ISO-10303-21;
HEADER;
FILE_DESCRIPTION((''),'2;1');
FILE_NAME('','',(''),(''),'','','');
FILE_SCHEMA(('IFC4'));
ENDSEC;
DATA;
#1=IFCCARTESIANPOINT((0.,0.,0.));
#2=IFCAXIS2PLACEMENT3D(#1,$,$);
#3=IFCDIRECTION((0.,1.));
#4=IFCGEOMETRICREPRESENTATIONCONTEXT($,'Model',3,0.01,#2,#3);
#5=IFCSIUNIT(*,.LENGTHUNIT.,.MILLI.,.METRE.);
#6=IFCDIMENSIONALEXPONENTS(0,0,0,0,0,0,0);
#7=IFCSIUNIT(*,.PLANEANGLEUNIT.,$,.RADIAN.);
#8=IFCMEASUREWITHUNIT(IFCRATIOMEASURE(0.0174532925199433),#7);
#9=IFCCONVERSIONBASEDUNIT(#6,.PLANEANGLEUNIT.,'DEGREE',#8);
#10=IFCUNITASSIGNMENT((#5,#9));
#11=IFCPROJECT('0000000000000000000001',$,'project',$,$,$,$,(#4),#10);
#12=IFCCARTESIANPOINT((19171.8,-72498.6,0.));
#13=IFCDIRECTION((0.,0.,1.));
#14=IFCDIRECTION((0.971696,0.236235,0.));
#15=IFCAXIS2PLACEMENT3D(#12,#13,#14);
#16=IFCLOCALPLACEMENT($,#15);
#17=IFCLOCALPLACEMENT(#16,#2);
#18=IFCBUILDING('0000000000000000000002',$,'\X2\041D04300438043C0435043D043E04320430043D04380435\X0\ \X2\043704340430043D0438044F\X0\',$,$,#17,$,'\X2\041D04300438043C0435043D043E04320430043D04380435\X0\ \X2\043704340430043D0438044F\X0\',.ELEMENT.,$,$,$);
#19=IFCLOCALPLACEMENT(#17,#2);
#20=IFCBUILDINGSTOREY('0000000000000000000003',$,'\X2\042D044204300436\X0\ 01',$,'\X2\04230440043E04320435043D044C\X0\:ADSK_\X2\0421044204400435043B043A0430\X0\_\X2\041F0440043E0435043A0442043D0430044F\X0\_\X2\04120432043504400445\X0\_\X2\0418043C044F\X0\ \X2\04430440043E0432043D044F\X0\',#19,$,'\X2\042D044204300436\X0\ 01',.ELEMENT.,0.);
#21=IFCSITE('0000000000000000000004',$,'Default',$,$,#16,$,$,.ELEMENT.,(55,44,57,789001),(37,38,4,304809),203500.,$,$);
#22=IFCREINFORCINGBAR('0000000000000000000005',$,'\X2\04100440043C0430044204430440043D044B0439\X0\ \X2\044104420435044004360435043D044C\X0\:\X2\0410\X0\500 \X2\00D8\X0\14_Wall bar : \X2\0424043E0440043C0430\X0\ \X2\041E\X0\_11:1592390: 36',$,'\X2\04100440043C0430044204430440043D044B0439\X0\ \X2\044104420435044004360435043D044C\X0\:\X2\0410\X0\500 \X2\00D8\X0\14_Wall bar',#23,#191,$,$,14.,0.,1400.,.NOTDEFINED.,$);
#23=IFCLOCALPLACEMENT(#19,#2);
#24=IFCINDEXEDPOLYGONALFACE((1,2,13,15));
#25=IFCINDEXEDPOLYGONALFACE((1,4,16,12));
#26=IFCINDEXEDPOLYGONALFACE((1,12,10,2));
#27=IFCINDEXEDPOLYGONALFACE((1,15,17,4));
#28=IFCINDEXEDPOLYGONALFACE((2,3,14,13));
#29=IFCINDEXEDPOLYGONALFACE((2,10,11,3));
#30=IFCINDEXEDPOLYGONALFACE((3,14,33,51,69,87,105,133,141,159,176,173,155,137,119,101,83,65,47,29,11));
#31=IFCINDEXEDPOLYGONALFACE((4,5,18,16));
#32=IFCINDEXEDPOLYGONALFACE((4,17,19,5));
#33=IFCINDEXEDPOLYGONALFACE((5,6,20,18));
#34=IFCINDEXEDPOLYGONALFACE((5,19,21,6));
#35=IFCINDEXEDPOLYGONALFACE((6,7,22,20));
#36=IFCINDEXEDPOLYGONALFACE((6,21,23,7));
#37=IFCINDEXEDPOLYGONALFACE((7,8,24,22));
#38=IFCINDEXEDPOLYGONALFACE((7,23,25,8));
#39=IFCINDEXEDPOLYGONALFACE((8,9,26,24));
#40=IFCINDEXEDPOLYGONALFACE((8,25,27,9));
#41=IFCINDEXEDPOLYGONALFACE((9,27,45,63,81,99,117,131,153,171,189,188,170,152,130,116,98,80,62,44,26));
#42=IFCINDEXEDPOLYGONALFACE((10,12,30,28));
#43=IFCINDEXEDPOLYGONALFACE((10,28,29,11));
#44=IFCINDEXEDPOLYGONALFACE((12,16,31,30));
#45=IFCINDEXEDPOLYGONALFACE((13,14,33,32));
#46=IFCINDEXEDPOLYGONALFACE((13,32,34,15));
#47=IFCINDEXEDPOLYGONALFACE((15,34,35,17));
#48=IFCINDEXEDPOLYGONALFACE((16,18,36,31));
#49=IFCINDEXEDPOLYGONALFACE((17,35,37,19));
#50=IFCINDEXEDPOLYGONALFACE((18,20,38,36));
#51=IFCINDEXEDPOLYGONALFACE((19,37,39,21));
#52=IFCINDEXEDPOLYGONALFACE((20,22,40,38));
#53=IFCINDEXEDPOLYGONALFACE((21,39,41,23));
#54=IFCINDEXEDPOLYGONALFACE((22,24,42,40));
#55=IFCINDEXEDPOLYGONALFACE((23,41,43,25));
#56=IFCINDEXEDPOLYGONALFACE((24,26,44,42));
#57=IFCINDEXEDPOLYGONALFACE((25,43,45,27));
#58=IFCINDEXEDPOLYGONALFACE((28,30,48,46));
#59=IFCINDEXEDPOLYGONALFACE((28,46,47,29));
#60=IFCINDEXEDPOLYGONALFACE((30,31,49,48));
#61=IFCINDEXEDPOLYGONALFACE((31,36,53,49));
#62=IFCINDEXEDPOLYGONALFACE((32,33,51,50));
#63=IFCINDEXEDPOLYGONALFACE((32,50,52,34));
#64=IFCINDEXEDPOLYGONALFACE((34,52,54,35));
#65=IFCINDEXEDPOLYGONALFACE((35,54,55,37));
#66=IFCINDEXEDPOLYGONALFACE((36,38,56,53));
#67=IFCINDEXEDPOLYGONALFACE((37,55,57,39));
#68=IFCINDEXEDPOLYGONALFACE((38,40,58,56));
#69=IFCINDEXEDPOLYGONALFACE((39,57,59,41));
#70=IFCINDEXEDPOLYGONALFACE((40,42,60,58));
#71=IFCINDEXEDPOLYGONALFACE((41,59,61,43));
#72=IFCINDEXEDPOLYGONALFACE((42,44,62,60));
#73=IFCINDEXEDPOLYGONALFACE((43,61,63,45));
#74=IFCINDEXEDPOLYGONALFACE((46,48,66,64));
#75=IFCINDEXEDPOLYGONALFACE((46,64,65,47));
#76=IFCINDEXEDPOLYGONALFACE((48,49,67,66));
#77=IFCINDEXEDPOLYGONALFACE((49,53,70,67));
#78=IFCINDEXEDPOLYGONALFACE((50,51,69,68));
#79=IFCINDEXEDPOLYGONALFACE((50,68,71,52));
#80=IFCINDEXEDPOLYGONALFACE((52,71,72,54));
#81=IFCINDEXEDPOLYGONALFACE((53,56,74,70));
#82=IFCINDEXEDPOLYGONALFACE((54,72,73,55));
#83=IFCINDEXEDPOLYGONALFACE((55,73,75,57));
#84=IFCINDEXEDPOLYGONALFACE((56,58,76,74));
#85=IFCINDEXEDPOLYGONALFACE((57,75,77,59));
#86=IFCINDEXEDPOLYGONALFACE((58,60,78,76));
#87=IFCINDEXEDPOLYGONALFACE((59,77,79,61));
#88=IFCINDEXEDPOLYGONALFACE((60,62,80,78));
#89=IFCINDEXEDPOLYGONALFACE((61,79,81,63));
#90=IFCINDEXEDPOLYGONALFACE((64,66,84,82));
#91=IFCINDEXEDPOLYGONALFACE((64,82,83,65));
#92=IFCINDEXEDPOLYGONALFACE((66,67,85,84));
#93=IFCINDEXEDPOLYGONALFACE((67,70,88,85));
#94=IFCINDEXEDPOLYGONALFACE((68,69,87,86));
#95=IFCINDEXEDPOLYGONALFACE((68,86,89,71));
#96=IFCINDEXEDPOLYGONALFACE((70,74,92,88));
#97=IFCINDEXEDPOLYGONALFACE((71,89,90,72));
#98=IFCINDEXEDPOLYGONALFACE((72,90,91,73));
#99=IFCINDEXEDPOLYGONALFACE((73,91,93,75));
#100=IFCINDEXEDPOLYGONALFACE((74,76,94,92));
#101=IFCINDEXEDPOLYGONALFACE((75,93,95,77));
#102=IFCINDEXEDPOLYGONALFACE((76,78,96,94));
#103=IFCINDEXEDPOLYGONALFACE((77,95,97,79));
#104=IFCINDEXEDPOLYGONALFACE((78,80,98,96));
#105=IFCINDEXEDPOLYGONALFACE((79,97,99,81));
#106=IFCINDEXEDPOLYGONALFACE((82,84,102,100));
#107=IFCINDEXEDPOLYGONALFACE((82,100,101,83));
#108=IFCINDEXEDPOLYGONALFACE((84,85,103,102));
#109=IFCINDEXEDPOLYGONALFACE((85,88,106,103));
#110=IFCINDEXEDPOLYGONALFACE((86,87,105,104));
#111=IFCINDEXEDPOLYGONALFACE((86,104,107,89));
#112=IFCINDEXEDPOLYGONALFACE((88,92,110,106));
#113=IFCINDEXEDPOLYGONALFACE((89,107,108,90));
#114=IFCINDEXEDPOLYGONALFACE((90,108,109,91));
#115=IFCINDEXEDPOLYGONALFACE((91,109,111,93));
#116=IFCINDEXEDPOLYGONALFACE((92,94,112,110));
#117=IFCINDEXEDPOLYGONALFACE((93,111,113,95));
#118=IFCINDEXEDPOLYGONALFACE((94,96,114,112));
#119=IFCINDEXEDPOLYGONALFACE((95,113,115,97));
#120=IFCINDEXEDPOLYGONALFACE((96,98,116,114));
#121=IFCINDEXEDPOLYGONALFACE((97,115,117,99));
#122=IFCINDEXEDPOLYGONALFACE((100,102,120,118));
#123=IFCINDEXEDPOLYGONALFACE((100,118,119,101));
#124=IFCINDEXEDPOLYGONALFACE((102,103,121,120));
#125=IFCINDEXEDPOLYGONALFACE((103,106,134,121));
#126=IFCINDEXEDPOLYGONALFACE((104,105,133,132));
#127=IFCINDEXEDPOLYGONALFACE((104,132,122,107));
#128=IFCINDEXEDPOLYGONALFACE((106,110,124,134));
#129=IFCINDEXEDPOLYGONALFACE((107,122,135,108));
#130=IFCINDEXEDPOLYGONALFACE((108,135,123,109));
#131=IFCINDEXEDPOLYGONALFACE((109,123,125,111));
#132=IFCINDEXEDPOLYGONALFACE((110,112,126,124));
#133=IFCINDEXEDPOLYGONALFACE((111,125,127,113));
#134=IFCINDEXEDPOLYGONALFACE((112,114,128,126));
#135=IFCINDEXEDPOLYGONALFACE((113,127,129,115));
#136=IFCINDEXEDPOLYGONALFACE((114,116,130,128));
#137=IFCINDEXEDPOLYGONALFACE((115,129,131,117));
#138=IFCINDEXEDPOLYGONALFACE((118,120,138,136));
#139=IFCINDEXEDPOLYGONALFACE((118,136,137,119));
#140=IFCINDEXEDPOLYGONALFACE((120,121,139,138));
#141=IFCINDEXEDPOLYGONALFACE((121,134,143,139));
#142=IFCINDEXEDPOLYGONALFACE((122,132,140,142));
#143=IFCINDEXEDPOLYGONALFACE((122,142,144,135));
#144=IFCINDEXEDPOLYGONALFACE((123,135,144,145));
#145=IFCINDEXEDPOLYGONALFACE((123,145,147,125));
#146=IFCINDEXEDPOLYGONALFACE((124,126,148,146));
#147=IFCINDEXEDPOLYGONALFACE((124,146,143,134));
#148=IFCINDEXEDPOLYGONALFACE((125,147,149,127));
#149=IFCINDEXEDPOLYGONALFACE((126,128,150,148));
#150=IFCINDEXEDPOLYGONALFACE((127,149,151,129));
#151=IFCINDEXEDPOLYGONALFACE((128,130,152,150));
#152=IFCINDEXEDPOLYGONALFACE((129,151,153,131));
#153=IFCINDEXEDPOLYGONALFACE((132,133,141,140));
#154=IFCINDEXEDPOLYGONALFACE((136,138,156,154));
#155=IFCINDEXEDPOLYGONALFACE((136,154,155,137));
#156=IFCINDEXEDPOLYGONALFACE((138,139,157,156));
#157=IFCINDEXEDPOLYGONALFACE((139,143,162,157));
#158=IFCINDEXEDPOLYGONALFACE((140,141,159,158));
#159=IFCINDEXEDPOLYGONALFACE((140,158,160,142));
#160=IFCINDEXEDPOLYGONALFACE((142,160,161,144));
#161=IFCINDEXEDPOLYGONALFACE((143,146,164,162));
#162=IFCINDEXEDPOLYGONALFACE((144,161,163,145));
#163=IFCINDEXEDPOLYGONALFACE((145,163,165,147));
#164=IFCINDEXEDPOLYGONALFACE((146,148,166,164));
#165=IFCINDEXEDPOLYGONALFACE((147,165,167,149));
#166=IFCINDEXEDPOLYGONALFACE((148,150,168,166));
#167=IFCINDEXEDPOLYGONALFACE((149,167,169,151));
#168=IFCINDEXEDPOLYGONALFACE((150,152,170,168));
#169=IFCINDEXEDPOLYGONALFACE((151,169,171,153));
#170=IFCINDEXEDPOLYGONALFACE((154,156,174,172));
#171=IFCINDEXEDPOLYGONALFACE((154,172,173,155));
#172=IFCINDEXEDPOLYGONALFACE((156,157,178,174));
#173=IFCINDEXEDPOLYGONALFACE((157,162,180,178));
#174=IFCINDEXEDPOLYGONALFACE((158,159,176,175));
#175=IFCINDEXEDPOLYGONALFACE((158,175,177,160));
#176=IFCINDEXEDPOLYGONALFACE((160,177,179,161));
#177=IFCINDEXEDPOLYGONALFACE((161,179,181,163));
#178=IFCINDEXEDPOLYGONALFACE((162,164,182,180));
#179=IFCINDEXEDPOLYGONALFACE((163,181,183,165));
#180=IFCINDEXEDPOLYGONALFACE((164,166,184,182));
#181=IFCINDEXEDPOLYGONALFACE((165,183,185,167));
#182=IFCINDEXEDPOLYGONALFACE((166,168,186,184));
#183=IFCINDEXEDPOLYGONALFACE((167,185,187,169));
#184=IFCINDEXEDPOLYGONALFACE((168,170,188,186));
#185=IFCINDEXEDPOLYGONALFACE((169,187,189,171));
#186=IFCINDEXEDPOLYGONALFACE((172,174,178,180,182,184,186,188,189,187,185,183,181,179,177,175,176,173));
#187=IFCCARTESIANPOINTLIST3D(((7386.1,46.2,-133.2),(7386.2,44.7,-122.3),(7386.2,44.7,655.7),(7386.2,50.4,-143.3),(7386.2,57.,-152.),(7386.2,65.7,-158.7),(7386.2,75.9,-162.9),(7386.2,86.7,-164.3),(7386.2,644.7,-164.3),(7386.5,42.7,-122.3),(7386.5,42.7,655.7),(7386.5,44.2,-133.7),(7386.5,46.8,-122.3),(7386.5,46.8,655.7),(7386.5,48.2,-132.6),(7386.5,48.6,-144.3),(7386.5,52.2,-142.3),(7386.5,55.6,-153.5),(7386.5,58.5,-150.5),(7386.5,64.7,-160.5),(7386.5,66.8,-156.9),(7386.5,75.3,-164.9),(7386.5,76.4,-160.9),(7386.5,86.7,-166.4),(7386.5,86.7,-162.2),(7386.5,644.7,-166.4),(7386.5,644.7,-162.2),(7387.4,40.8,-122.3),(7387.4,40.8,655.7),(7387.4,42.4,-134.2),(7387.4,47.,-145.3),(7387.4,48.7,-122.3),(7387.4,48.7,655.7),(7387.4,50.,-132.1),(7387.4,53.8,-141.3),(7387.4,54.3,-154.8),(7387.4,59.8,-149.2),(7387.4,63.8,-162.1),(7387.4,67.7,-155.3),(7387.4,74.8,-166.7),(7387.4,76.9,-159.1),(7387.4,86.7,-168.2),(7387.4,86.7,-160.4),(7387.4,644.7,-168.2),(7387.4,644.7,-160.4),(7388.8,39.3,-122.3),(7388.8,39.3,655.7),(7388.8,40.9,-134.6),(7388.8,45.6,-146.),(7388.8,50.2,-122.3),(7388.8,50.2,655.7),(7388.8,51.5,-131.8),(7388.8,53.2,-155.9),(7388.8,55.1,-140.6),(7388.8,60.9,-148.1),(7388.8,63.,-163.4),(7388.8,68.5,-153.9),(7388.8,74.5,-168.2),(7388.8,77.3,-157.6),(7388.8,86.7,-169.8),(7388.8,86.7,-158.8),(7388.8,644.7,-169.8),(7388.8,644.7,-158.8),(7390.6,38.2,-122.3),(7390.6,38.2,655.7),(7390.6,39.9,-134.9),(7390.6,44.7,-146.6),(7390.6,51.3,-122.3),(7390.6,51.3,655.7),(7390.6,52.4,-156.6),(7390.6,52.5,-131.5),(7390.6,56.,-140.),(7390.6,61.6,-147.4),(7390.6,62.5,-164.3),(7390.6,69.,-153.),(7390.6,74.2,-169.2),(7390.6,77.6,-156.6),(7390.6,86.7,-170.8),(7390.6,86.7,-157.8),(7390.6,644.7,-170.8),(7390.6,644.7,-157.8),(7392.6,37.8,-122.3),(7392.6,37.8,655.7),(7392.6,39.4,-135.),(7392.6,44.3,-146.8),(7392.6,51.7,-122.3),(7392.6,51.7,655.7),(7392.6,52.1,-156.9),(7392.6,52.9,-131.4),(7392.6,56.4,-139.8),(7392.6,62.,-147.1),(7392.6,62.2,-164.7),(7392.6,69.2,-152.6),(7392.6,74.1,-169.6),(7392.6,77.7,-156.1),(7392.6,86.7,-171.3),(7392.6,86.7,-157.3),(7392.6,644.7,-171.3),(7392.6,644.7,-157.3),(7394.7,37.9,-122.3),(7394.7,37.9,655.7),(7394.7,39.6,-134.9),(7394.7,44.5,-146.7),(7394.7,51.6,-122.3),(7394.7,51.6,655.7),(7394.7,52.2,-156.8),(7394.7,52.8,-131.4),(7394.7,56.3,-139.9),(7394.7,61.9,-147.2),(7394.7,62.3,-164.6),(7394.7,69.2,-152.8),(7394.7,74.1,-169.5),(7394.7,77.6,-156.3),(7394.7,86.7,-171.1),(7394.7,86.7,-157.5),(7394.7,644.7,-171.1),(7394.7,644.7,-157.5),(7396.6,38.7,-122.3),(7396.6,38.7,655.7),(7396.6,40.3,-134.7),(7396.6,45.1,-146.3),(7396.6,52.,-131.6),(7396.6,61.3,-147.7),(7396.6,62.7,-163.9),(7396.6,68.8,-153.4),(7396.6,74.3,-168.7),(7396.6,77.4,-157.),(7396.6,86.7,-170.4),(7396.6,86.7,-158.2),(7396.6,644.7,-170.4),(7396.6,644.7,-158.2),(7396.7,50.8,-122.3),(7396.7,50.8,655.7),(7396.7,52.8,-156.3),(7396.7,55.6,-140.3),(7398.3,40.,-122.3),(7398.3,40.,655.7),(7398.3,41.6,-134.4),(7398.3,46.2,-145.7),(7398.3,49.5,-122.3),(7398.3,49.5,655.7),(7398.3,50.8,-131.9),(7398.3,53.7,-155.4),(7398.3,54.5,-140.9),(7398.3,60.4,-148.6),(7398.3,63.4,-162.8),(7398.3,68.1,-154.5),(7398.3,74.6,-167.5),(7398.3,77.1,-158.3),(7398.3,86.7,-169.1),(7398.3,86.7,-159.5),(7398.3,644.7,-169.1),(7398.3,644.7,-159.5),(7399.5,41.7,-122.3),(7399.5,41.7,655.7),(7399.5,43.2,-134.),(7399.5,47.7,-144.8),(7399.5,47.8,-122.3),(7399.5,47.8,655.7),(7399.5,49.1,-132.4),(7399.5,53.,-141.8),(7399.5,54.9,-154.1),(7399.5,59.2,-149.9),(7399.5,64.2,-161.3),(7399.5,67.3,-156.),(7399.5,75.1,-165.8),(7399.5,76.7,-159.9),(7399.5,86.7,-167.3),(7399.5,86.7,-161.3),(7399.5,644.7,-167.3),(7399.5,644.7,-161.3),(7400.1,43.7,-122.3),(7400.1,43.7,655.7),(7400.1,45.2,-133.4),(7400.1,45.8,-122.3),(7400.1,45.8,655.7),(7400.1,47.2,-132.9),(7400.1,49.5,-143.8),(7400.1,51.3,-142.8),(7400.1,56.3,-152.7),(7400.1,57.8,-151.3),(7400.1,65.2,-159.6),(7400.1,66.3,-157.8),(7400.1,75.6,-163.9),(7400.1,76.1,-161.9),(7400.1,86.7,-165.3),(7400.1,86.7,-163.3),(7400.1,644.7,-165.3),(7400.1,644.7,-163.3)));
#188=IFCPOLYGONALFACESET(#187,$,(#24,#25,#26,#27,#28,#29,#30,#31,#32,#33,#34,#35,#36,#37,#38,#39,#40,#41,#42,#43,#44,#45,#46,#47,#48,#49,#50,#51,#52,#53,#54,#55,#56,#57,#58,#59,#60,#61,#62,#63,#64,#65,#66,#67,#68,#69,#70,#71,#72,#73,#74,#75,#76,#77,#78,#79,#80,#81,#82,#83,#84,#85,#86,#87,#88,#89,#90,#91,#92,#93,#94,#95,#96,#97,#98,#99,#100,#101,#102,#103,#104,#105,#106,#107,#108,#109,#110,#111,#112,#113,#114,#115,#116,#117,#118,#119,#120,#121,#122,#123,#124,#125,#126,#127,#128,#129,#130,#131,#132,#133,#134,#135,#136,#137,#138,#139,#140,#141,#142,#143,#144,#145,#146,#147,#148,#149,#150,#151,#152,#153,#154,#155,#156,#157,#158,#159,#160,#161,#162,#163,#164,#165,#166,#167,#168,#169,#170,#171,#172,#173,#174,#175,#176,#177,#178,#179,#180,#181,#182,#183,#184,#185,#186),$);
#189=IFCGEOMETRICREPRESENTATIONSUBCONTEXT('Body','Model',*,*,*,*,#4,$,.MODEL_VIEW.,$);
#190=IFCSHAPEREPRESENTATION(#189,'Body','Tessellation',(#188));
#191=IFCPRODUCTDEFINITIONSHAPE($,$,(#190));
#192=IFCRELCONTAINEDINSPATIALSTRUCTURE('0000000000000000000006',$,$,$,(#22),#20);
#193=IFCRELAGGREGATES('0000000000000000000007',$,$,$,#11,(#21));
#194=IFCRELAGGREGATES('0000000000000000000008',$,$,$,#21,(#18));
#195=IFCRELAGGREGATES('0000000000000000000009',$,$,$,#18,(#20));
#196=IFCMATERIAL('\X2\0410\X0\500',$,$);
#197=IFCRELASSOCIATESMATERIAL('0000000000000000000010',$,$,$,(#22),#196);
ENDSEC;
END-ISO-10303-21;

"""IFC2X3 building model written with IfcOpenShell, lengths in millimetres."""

from ifc_helpers import new_model, entity, si_unit, converted_unit, direction, frame, origin, place, context, subcontext, project, spatial, material, element, save


model = new_model("IFC2X3")

# Units and contexts
model_context = context("Model", 3, precision=0.01, world=origin(), true_north=direction((0.0, 1.0)))
body_context = subcontext(model_context, "Body", "Model", "MODEL_VIEW")
ifc_project = project(units=[si_unit("LENGTHUNIT", "METRE", prefix="MILLI"), converted_unit("PLANEANGLEUNIT", "DEGREE", entity("IfcRatioMeasure", 0.0174532925199433), si_unit("PLANEANGLEUNIT", "RADIAN"), dimensions=[0, 0, 0, 0, 0, 0, 0])], contexts=[model_context])

# Site, building, storey
site_placement = place(None, frame((19171.8, -72498.6, 0.0), z_axis=(0.0, 0.0, 1.0), x_axis=(0.971696, 0.236235, 0.0)))
site = spatial("IfcSite", under=ifc_project, at=site_placement, Name="Default", CompositionType="ELEMENT", RefLatitude=(55, 44, 57, 789001), RefLongitude=(37, 38, 4, 304809), RefElevation=203500.0)
building_placement = place(site_placement, origin())
building = spatial("IfcBuilding", under=site, at=building_placement, Name="Наименование здания", LongName="Наименование здания", CompositionType="ELEMENT")
storey_placement = place(building_placement, origin())
storey = spatial("IfcBuildingStorey", under=building, at=storey_placement, Name="Этаж 01", ObjectType="Уровень:ADSK_Стрелка_Проектная_Вверх_Имя уровня", LongName="Этаж 01", CompositionType="ELEMENT", Elevation=0.0)

# Reinforcing bar
ifc_material = material(Name="А500")
placement = place(storey_placement, origin())
element("IfcReinforcingBar", 1, at=placement, inside=storey, material=ifc_material, Name="Арматурный стержень:А500 Ø14_Wall bar : Форма О_11:1592390: 36", ObjectType="Арматурный стержень:А500 Ø14_Wall bar", BarLength=1400.0, BarRole="NOTDEFINED", CrossSectionArea=0.0, NominalDiameter=14.0, context=body_context, shape_type="AdvancedSweptSolid", body=[
    entity("IfcSweptDiskSolid", entity("IfcCompositeCurve", [entity("IfcCompositeCurveSegment", "CONTINUOUS", True, entity("IfcPolyline", [entity("IfcCartesianPoint", [7393.1, 44.7, 655.7]), entity("IfcCartesianPoint", [7393.1, 44.7, -122.3])])), entity("IfcCompositeCurveSegment", "CONTINUOUS", True, entity("IfcTrimmedCurve", entity("IfcCircle", entity("IfcAxis2Placement3D", entity("IfcCartesianPoint", [7393.1, 86.7, -122.3]), entity("IfcDirection", [1.0, 0.0, 0.0]), entity("IfcDirection", [0.0, 0.0, -1.0])), 42.0), [entity("IfcParameterValue", 270.0)], [entity("IfcParameterValue", 360.0)], True, "PARAMETER")), entity("IfcCompositeCurveSegment", "CONTINUOUS", True, entity("IfcPolyline", [entity("IfcCartesianPoint", [7393.1, 86.7, -164.3]), entity("IfcCartesianPoint", [7393.1, 644.7, -164.3])]))], False), 7.0, None, 0.0, 92.0),
])

save(model, "model.ifc")
